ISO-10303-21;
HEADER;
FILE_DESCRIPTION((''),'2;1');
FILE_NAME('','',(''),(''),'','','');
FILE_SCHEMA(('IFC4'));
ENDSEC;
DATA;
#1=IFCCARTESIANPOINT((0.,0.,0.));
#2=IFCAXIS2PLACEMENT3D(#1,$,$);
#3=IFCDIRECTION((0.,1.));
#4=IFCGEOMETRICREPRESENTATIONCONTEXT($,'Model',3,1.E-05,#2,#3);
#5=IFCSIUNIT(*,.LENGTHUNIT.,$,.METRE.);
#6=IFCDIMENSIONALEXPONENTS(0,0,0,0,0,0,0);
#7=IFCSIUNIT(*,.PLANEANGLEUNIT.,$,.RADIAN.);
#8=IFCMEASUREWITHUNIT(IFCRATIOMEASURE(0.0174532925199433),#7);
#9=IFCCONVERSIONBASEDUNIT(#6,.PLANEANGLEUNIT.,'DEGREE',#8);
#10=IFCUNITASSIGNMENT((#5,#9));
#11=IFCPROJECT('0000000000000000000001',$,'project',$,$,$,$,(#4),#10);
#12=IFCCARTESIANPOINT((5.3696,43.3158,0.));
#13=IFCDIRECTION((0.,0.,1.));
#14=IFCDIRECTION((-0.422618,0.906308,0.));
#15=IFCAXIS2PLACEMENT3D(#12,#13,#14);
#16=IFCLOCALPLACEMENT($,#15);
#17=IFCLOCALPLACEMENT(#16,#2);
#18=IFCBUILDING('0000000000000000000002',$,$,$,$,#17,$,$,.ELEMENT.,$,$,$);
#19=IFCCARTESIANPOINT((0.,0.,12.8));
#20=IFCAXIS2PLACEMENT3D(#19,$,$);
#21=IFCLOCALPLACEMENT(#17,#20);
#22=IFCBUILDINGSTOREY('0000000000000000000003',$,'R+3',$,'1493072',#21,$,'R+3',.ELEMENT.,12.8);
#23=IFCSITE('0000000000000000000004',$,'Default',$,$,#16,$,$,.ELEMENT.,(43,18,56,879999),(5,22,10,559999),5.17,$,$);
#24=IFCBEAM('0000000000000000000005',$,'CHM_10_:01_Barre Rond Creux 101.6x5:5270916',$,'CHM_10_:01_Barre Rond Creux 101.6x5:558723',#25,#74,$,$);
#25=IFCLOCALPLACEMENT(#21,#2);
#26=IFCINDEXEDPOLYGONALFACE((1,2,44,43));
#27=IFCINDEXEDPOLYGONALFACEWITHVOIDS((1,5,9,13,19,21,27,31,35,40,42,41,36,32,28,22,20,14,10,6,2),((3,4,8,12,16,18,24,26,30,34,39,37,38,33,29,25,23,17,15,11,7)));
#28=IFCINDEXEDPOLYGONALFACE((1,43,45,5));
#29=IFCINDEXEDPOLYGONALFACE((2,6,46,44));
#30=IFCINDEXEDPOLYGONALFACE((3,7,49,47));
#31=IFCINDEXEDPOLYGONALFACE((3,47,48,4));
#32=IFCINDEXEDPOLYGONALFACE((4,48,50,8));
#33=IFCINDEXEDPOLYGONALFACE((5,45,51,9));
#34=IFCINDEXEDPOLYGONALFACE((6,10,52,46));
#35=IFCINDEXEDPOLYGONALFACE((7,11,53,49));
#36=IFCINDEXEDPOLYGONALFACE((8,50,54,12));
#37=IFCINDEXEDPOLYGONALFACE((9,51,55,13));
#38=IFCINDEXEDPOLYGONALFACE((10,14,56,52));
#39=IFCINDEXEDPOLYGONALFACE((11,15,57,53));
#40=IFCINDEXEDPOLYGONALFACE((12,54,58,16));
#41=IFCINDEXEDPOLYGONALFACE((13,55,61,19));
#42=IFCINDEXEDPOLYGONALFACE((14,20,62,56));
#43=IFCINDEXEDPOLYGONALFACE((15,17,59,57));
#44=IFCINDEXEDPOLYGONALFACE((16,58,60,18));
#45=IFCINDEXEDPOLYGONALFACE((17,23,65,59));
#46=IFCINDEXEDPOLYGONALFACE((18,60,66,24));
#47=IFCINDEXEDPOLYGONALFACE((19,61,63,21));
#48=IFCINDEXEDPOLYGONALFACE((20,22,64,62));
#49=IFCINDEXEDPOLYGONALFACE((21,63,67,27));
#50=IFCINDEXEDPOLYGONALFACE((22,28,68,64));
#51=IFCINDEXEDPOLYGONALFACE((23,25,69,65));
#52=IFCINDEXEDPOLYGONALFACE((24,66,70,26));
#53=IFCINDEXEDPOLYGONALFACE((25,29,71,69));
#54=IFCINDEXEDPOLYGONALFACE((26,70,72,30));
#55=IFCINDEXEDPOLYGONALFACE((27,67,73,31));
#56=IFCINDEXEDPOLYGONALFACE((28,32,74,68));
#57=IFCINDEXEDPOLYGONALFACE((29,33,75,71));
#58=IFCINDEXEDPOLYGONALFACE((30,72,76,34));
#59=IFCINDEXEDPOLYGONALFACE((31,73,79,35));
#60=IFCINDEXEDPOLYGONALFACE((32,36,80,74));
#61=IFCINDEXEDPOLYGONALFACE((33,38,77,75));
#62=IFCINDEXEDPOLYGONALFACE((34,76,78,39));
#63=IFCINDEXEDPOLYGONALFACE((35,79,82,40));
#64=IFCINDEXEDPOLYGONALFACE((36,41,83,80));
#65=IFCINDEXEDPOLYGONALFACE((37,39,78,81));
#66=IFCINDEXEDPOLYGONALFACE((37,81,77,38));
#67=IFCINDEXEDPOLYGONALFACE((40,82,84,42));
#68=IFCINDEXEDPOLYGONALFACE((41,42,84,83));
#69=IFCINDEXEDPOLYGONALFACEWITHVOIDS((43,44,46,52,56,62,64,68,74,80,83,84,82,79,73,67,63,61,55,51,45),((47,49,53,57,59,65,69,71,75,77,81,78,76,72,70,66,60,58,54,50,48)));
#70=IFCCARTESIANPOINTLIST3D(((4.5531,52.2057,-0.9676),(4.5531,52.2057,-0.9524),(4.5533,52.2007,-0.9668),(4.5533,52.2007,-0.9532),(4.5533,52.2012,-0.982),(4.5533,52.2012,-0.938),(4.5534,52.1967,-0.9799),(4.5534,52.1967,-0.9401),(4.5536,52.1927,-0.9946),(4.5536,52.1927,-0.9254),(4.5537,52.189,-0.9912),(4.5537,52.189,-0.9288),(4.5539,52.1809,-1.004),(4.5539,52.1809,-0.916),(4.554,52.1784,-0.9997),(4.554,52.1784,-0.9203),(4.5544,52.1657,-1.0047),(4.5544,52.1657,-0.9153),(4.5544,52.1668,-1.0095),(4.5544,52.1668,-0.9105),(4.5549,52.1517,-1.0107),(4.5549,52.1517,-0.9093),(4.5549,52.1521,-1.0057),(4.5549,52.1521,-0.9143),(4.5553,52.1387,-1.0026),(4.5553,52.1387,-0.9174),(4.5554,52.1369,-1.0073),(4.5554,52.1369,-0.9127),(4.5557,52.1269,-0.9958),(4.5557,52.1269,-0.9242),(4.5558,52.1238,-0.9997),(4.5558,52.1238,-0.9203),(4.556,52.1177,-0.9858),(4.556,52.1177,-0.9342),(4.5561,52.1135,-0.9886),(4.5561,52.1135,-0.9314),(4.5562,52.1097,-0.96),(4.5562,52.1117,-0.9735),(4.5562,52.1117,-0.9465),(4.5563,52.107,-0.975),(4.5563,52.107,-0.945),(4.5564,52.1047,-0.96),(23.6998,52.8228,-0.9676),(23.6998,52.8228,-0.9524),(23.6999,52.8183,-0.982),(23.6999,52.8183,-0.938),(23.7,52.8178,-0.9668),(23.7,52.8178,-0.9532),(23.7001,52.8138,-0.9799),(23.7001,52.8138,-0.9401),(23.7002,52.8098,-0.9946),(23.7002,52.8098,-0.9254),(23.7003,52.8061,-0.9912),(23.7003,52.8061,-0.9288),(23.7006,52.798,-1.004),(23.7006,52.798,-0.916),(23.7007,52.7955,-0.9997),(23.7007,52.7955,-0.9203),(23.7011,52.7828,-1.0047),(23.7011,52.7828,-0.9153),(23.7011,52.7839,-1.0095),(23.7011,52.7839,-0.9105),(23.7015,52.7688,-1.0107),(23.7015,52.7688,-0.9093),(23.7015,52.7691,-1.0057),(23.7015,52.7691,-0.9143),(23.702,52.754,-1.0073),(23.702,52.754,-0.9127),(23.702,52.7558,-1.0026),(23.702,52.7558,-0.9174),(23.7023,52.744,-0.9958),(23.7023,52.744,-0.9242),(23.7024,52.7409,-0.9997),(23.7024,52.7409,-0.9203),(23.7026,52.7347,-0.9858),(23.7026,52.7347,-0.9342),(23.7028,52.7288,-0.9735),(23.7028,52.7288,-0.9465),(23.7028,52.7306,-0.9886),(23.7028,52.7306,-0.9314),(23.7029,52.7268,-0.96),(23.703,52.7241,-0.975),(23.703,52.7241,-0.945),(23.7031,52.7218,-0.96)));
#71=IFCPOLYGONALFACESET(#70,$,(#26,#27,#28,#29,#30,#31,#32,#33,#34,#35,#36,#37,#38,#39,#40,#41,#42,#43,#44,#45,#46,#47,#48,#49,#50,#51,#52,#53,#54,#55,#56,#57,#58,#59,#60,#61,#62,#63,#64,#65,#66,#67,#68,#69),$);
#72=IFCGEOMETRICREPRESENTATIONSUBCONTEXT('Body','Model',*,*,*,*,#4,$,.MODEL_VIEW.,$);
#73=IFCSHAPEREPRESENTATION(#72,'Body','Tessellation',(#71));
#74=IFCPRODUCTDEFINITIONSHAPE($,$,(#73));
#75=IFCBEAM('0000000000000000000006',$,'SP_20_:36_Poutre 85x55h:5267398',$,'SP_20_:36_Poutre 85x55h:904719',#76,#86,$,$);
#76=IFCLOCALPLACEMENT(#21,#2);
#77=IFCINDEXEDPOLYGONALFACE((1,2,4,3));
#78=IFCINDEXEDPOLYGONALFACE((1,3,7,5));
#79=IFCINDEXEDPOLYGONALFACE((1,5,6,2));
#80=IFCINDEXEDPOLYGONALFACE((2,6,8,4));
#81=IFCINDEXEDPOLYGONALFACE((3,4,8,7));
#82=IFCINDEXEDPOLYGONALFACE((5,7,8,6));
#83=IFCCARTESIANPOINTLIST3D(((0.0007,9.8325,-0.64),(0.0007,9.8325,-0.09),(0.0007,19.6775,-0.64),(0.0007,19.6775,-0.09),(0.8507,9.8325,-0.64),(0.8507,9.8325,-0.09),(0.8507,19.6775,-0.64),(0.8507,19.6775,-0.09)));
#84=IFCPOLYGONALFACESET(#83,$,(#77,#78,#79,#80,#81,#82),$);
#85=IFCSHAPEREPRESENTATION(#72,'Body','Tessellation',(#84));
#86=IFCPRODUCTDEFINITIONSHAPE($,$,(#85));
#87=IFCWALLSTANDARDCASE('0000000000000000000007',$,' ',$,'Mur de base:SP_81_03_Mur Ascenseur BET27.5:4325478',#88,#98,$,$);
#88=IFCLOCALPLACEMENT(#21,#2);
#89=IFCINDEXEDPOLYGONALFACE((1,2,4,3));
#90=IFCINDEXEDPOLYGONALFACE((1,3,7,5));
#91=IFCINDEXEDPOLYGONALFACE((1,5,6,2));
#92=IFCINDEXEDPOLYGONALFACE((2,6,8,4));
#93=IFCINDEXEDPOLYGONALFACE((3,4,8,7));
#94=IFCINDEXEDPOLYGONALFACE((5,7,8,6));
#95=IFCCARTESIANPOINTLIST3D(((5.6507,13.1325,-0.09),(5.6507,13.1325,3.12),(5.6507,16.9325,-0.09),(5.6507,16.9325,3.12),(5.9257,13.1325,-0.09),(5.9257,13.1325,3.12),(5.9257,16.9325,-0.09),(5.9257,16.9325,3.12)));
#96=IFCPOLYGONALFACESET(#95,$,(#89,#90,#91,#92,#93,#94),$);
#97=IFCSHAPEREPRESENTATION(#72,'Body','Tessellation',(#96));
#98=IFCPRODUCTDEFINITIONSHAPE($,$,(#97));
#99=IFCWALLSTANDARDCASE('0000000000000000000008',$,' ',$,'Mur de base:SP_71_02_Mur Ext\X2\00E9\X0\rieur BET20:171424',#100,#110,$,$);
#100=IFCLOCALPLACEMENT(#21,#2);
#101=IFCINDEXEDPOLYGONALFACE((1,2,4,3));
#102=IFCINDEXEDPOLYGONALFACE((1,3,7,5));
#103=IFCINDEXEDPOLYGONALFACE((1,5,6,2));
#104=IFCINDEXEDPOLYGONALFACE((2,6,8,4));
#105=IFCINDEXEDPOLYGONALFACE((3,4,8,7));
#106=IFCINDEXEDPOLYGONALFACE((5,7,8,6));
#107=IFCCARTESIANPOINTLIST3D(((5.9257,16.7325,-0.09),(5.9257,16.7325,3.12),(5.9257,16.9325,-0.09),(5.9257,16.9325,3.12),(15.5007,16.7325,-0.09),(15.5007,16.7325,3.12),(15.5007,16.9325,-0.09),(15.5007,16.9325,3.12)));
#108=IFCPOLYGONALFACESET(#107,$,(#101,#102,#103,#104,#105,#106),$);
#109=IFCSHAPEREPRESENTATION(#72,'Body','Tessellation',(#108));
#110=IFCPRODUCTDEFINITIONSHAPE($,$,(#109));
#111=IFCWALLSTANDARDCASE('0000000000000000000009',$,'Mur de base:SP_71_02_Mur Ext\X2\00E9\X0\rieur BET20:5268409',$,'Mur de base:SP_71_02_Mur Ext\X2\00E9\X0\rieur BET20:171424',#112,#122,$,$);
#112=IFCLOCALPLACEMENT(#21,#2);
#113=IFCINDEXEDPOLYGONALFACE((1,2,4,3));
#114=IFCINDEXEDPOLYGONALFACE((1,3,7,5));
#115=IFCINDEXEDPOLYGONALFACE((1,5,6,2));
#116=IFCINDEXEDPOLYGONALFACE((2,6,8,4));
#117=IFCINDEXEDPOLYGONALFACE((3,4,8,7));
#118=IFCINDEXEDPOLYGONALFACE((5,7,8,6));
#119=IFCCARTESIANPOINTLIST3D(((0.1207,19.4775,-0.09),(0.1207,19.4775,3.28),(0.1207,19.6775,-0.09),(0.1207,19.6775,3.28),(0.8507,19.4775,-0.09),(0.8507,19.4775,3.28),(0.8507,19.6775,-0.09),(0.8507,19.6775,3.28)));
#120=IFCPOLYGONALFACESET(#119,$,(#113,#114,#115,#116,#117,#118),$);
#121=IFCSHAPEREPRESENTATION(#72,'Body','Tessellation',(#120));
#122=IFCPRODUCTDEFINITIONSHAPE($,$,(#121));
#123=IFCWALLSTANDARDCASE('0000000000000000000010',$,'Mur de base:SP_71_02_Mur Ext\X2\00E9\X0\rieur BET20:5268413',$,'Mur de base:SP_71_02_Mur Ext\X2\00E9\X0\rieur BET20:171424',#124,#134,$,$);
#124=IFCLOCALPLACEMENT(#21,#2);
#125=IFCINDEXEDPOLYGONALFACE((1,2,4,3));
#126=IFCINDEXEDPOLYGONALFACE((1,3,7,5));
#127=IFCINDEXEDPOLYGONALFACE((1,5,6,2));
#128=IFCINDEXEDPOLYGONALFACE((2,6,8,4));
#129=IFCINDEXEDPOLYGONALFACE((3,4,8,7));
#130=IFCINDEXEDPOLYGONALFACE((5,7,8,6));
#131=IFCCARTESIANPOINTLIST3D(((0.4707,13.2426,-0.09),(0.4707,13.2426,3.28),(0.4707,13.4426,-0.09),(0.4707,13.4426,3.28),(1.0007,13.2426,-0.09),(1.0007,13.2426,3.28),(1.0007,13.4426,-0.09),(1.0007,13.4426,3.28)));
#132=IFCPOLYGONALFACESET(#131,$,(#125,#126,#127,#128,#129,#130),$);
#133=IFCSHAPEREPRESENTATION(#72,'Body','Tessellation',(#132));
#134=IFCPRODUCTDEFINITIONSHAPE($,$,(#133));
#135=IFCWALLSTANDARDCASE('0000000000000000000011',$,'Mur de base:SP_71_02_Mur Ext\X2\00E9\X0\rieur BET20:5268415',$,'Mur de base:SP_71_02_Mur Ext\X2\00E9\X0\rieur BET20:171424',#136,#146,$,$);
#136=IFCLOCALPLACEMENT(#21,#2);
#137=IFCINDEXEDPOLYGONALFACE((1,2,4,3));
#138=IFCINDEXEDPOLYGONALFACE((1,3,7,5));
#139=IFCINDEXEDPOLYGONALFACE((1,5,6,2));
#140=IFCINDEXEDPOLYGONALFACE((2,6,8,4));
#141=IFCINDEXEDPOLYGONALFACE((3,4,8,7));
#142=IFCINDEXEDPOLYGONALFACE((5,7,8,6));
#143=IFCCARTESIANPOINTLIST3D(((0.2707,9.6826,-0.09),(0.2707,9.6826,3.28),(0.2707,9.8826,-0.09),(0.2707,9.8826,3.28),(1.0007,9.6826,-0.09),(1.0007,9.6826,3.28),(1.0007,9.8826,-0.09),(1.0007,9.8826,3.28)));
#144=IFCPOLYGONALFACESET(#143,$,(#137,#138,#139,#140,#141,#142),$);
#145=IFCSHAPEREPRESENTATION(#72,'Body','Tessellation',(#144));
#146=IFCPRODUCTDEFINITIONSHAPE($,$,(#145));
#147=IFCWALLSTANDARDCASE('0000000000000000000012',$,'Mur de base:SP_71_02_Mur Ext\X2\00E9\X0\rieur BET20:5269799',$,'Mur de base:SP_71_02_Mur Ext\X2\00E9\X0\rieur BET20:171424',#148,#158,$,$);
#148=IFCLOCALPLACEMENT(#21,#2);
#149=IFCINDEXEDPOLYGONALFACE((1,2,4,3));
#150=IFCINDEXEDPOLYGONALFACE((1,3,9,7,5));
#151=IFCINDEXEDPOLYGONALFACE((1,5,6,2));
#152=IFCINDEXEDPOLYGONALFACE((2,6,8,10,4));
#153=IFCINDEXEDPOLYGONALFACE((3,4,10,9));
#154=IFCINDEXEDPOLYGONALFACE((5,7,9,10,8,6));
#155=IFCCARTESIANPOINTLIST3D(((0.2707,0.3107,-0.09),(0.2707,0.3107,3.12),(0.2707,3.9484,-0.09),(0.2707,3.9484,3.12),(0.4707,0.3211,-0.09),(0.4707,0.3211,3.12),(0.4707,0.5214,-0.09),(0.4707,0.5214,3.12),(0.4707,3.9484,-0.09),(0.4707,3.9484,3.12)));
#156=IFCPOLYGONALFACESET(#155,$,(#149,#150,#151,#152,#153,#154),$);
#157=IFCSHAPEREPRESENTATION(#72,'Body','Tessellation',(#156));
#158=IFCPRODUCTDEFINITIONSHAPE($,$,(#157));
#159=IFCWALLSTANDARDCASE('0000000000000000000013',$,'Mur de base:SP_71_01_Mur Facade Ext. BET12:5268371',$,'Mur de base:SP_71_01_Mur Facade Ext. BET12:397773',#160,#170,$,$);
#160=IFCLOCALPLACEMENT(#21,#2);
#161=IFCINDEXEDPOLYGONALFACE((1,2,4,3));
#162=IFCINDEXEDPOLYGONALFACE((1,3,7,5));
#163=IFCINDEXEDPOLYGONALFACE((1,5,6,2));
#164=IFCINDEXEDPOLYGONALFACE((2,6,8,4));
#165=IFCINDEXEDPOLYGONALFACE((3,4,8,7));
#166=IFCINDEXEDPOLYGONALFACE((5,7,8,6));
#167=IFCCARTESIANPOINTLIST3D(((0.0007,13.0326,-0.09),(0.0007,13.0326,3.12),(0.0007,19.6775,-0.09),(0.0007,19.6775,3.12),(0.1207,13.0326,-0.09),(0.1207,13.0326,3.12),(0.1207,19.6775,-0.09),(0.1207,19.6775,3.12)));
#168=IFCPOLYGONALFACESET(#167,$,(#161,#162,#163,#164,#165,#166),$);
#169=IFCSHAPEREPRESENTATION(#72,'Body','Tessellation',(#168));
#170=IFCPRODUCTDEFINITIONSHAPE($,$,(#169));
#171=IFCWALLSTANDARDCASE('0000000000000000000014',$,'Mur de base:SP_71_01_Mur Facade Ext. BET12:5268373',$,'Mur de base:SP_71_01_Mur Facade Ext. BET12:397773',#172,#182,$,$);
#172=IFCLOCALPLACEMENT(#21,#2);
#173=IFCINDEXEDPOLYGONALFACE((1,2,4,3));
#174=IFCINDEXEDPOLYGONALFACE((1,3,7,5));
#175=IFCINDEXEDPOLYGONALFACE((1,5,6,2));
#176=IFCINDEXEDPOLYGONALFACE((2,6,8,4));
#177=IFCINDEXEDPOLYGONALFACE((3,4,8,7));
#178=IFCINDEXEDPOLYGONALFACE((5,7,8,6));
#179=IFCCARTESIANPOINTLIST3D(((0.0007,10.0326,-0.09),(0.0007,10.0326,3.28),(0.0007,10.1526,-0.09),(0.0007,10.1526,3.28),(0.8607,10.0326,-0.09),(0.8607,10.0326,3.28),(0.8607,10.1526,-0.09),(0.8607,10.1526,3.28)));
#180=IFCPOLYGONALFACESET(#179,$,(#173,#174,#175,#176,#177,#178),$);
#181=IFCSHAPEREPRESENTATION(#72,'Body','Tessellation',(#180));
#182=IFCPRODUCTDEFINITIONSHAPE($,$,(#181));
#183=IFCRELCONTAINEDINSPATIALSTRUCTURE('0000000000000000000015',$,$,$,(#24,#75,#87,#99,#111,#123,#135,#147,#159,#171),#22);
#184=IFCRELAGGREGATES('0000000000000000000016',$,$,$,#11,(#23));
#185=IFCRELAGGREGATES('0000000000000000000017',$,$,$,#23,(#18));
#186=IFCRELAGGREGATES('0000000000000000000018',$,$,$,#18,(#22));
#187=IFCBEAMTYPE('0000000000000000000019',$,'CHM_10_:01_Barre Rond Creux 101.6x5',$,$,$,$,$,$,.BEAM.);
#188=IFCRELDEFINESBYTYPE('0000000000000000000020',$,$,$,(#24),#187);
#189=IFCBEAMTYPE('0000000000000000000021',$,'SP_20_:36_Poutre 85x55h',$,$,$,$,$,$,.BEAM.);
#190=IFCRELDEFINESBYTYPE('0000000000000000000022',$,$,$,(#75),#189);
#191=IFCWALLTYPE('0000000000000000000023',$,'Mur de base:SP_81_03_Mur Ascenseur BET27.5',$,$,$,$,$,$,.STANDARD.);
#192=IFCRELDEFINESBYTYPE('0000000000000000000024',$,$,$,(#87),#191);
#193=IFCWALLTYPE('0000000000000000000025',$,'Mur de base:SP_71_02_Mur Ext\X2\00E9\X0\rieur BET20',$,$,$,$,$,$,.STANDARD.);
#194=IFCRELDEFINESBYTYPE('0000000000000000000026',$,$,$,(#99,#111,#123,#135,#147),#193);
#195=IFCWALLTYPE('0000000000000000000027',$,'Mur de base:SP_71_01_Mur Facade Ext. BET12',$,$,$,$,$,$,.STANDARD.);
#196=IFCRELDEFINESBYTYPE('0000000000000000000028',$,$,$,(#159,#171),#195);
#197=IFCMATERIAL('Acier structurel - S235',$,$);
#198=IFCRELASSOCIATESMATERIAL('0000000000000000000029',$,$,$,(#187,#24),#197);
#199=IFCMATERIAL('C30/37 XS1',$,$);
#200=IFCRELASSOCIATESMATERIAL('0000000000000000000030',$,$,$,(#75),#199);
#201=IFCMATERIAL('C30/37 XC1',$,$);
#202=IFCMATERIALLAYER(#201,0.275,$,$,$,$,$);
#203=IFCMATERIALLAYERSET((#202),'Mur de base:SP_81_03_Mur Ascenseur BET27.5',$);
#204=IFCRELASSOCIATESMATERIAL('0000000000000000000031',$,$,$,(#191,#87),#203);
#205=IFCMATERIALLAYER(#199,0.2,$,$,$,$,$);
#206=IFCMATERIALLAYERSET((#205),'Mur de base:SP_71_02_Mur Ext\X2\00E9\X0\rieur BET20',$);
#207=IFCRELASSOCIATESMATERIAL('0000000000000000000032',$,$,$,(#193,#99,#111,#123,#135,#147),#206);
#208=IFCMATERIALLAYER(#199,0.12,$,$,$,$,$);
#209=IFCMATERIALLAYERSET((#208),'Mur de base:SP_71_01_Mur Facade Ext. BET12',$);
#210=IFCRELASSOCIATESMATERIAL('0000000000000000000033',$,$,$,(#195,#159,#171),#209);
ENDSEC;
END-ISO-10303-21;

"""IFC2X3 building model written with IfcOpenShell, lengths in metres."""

from ifc_helpers import new_model, entity, si_unit, converted_unit, direction, frame, frame_2d, origin, origin_2d_with_axis, place, context, subcontext, project, spatial, polyline, rectangle, hollow_circle, outline, extrude, clip, bounded_halfspace, material, layer, layer_set, layer_usage, type_object, element, save


model = new_model("IFC2X3")

# Units and contexts
model_context = context("Model", 3, precision=1e-05, world=origin(), true_north=direction((0.0, 1.0)))
body_context = subcontext(model_context, "Body", "Model", "MODEL_VIEW")
ifc_project = project(units=[si_unit("LENGTHUNIT", "METRE"), converted_unit("PLANEANGLEUNIT", "DEGREE", entity("IfcRatioMeasure", 0.0174532925199433), si_unit("PLANEANGLEUNIT", "RADIAN"), dimensions=[0, 0, 0, 0, 0, 0, 0])], contexts=[model_context])

# Site, building, storey
site_placement = place(None, frame((5.3696, 43.3158, 0.0), z_axis=(0.0, 0.0, 1.0), x_axis=(-0.422618, 0.906308, 0.0)))
site = spatial("IfcSite", under=ifc_project, at=site_placement, Name="Default", CompositionType="ELEMENT", RefLatitude=(43, 18, 56, 879999), RefLongitude=(5, 22, 10, 559999), RefElevation=5.17)
building_placement = place(site_placement, origin())
building = spatial("IfcBuilding", under=site, at=building_placement, CompositionType="ELEMENT")
storey_placement = place(building_placement, frame((0.0, 0.0, 12.8)))
storey = spatial("IfcBuildingStorey", under=building, at=storey_placement, Name="R+3", ObjectType="1493072", LongName="R+3", CompositionType="ELEMENT", Elevation=12.8)

# Shared definitions
ifc_material_1 = material(Name="Acier structurel - S235")

# Beams
beam_type_1 = type_object("IfcBeamType", Name="CHM_10_:01_Barre Rond Creux 101.6x5", PredefinedType="BEAM", material=ifc_material_1)
beam_1_placement = place(storey_placement, frame((23.692, 52.7723, -0.96), z_axis=(0.0, 0.0, 1.0), x_axis=(-0.999481, -0.032213, 0.0)))
element("IfcBeam", 1, at=beam_1_placement, inside=storey, type_object=beam_type_1, material=ifc_material_1, Name="CHM_10_:01_Barre Rond Creux 101.6x5:5270916", ObjectType="CHM_10_:01_Barre Rond Creux 101.6x5:558723", context=body_context, shape_type="SweptSolid", body=[
    extrude(hollow_circle(Radius=0.0508, WallThickness=0.005, at=origin_2d_with_axis()), frame((-0.0094, 0.0, 0.0), z_axis=(1.0, 0.0, 0.0), x_axis=(0.0, 1.0, 0.0)), (0.0, 0.0, 1.0), 19.1566),
])
ifc_material_2 = material(Name="C30/37 XS1")
beam_type_2 = type_object("IfcBeamType", Name="SP_20_:36_Poutre 85x55h", PredefinedType="BEAM")
beam_2_placement = place(storey_placement, frame((0.4257, 19.5775, -0.09), z_axis=(0.0, 0.0, 1.0), x_axis=(0.0, -1.0, 0.0)))
element("IfcBeam", 2, at=beam_2_placement, inside=storey, type_object=beam_type_2, material=ifc_material_2, Name="SP_20_:36_Poutre 85x55h:5267398", ObjectType="SP_20_:36_Poutre 85x55h:904719", context=body_context, shape_type="SweptSolid", body=[
    extrude(rectangle(XDim=0.55, YDim=0.85, at=frame_2d((0.0, 0.0), x_axis=(1.0, 0.0))), frame((-0.1, 0.0, -0.275), z_axis=(1.0, 0.0, 0.0), x_axis=(0.0, 0.0, -1.0)), (0.0, 0.0, 1.0), 9.845),
])

# Walls
ifc_material_3 = material(Name="C30/37 XC1")
ifc_layer_1 = layer(ifc_material_3, 0.275)
ifc_layer_set_1 = layer_set([ifc_layer_1], Name="Mur de base:SP_81_03_Mur Ascenseur BET27.5")
ifc_layer_usage_1 = layer_usage(ifc_layer_set_1, "AXIS2", "NEGATIVE", 0.1375)
wall_type_1 = type_object("IfcWallType", Name="Mur de base:SP_81_03_Mur Ascenseur BET27.5", PredefinedType="STANDARD", material=ifc_layer_set_1)
wall_1_placement = place(storey_placement, frame((5.7882, 16.9325, -0.09), z_axis=(0.0, 0.0, 1.0), x_axis=(0.0, -1.0, 0.0)))
element("IfcWallStandardCase", 3, at=wall_1_placement, inside=storey, type_object=wall_type_1, material=ifc_layer_usage_1, Name=" ", ObjectType="Mur de base:SP_81_03_Mur Ascenseur BET27.5:4325478", context=body_context, shape_type="Clipping", body=[
    clip(extrude(rectangle(XDim=3.8, YDim=0.275, at=frame_2d((1.9, 0.0), x_axis=(-1.0, 0.0))), origin(), (0.0, 0.0, 1.0), 3.21), bounded_halfspace(frame((0.0, 0.1375, 3.21), z_axis=(0.0, 0.0, -1.0), x_axis=(-1.0, 0.0, 0.0)), True, frame((0.0, 0.1375, 3.21), z_axis=(0.0, 0.0, -1.0), x_axis=(-1.0, 0.0, 0.0)), polyline([(0.0, 0.0), (-0.2, 0.0), (-3.8, 0.0), (-3.8, -0.27), (-3.8, -0.275), (-3.3141, -0.275), (0.0, -0.275), (0.0, 0.0)]))),
])
ifc_layer_2 = layer(ifc_material_2, 0.2)
ifc_layer_set_2 = layer_set([ifc_layer_2], Name="Mur de base:SP_71_02_Mur Extérieur BET20")
ifc_layer_usage_2 = layer_usage(ifc_layer_set_2, "AXIS2", "NEGATIVE", 0.1)
wall_type_2 = type_object("IfcWallType", Name="Mur de base:SP_71_02_Mur Extérieur BET20", PredefinedType="STANDARD", material=ifc_layer_set_2)
wall_2_placement = place(storey_placement, frame((5.9257, 16.8325, -0.09)))
element("IfcWallStandardCase", 4, at=wall_2_placement, inside=storey, type_object=wall_type_2, material=ifc_layer_usage_2, Name=" ", ObjectType="Mur de base:SP_71_02_Mur Extérieur BET20:171424", context=body_context, shape_type="Clipping", body=[
    clip(extrude(rectangle(XDim=9.575, YDim=0.2, at=frame_2d((4.7875, 0.0), x_axis=(-1.0, 0.0))), origin(), (0.0, 0.0, 1.0), 3.21), bounded_halfspace(frame((0.0, -0.1, 3.21), z_axis=(0.0, 0.0, -1.0), x_axis=(0.0, 1.0, 0.0)), True, frame((0.0, -0.1, 3.21), z_axis=(0.0, 0.0, -1.0), x_axis=(0.0, 1.0, 0.0)), polyline([(0.0, 0.0), (0.2, 0.0), (0.2, 9.575), (0.0, 9.575), (0.0, 9.375), (0.0, 2.375), (0.0, 2.175), (0.0, 0.0)]))),
])
ifc_layer_usage_3 = layer_usage(ifc_layer_set_2, "AXIS2", "NEGATIVE", 0.1)
wall_3_placement = place(storey_placement, frame((0.1207, 19.5775, -0.09)))
element("IfcWallStandardCase", 5, at=wall_3_placement, inside=storey, type_object=wall_type_2, material=ifc_layer_usage_3, Name="Mur de base:SP_71_02_Mur Extérieur BET20:5268409", ObjectType="Mur de base:SP_71_02_Mur Extérieur BET20:171424", context=body_context, shape_type="SweptSolid", body=[
    extrude(rectangle(XDim=0.73, YDim=0.2, at=frame_2d((0.365, 0.0), x_axis=(-1.0, 0.0))), origin(), (0.0, 0.0, 1.0), 3.37),
])
ifc_layer_usage_4 = layer_usage(ifc_layer_set_2, "AXIS2", "NEGATIVE", 0.1)
wall_4_placement = place(storey_placement, frame((0.4707, 13.3426, -0.09)))
element("IfcWallStandardCase", 6, at=wall_4_placement, inside=storey, type_object=wall_type_2, material=ifc_layer_usage_4, Name="Mur de base:SP_71_02_Mur Extérieur BET20:5268413", ObjectType="Mur de base:SP_71_02_Mur Extérieur BET20:171424", context=body_context, shape_type="SweptSolid", body=[
    extrude(rectangle(XDim=0.53, YDim=0.2, at=frame_2d((0.265, 0.0), x_axis=(-1.0, 0.0))), origin(), (0.0, 0.0, 1.0), 3.37),
])
ifc_layer_usage_5 = layer_usage(ifc_layer_set_2, "AXIS2", "NEGATIVE", 0.1)
wall_5_placement = place(storey_placement, frame((1.0007, 9.7826, -0.09), z_axis=(0.0, 0.0, 1.0), x_axis=(-1.0, 0.0, 0.0)))
element("IfcWallStandardCase", 7, at=wall_5_placement, inside=storey, type_object=wall_type_2, material=ifc_layer_usage_5, Name="Mur de base:SP_71_02_Mur Extérieur BET20:5268415", ObjectType="Mur de base:SP_71_02_Mur Extérieur BET20:171424", context=body_context, shape_type="SweptSolid", body=[
    extrude(rectangle(XDim=0.73, YDim=0.2, at=frame_2d((0.365, 0.0), x_axis=(-1.0, 0.0))), origin(), (0.0, 0.0, 1.0), 3.37),
])
ifc_layer_usage_6 = layer_usage(ifc_layer_set_2, "AXIS2", "NEGATIVE", 0.1)
wall_6_placement = place(storey_placement, frame((0.3707, 3.9484, -0.09), z_axis=(0.0, 0.0, 1.0), x_axis=(0.0, -1.0, 0.0)))
element("IfcWallStandardCase", 8, at=wall_6_placement, inside=storey, type_object=wall_type_2, material=ifc_layer_usage_6, Name="Mur de base:SP_71_02_Mur Extérieur BET20:5269799", ObjectType="Mur de base:SP_71_02_Mur Extérieur BET20:171424", context=body_context, shape_type="SweptSolid", body=[
    extrude(outline(polyline([(3.6377, -0.1), (3.6273, 0.1), (3.427, 0.1), (0.0, 0.1), (0.0, -0.1), (3.6377, -0.1)])), origin(), (0.0, 0.0, 1.0), 3.21),
])
ifc_layer_3 = layer(ifc_material_2, 0.12)
ifc_layer_set_3 = layer_set([ifc_layer_3], Name="Mur de base:SP_71_01_Mur Facade Ext. BET12")
ifc_layer_usage_7 = layer_usage(ifc_layer_set_3, "AXIS2", "NEGATIVE", 0.06)
wall_type_3 = type_object("IfcWallType", Name="Mur de base:SP_71_01_Mur Facade Ext. BET12", PredefinedType="STANDARD", material=ifc_layer_set_3)
wall_7_placement = place(storey_placement, frame((0.0607, 19.6775, -0.09), z_axis=(0.0, 0.0, 1.0), x_axis=(0.0, -1.0, 0.0)))
element("IfcWallStandardCase", 9, at=wall_7_placement, inside=storey, type_object=wall_type_3, material=ifc_layer_usage_7, Name="Mur de base:SP_71_01_Mur Facade Ext. BET12:5268371", ObjectType="Mur de base:SP_71_01_Mur Facade Ext. BET12:397773", context=body_context, shape_type="SweptSolid", body=[
    extrude(rectangle(XDim=6.6449, YDim=0.12, at=frame_2d((3.3225, 0.0), x_axis=(-1.0, 0.0))), origin(), (0.0, 0.0, 1.0), 3.21),
])
ifc_layer_usage_8 = layer_usage(ifc_layer_set_3, "AXIS2", "NEGATIVE", 0.06)
wall_8_placement = place(storey_placement, frame((0.8607, 10.0926, -0.09), z_axis=(0.0, 0.0, 1.0), x_axis=(-1.0, 0.0, 0.0)))
element("IfcWallStandardCase", 10, at=wall_8_placement, inside=storey, type_object=wall_type_3, material=ifc_layer_usage_8, Name="Mur de base:SP_71_01_Mur Facade Ext. BET12:5268373", ObjectType="Mur de base:SP_71_01_Mur Facade Ext. BET12:397773", context=body_context, shape_type="SweptSolid", body=[
    extrude(rectangle(XDim=0.86, YDim=0.12, at=frame_2d((0.43, 0.0), x_axis=(-1.0, 0.0))), origin(), (0.0, 0.0, 1.0), 3.37),
])

save(model, "model.ifc")
